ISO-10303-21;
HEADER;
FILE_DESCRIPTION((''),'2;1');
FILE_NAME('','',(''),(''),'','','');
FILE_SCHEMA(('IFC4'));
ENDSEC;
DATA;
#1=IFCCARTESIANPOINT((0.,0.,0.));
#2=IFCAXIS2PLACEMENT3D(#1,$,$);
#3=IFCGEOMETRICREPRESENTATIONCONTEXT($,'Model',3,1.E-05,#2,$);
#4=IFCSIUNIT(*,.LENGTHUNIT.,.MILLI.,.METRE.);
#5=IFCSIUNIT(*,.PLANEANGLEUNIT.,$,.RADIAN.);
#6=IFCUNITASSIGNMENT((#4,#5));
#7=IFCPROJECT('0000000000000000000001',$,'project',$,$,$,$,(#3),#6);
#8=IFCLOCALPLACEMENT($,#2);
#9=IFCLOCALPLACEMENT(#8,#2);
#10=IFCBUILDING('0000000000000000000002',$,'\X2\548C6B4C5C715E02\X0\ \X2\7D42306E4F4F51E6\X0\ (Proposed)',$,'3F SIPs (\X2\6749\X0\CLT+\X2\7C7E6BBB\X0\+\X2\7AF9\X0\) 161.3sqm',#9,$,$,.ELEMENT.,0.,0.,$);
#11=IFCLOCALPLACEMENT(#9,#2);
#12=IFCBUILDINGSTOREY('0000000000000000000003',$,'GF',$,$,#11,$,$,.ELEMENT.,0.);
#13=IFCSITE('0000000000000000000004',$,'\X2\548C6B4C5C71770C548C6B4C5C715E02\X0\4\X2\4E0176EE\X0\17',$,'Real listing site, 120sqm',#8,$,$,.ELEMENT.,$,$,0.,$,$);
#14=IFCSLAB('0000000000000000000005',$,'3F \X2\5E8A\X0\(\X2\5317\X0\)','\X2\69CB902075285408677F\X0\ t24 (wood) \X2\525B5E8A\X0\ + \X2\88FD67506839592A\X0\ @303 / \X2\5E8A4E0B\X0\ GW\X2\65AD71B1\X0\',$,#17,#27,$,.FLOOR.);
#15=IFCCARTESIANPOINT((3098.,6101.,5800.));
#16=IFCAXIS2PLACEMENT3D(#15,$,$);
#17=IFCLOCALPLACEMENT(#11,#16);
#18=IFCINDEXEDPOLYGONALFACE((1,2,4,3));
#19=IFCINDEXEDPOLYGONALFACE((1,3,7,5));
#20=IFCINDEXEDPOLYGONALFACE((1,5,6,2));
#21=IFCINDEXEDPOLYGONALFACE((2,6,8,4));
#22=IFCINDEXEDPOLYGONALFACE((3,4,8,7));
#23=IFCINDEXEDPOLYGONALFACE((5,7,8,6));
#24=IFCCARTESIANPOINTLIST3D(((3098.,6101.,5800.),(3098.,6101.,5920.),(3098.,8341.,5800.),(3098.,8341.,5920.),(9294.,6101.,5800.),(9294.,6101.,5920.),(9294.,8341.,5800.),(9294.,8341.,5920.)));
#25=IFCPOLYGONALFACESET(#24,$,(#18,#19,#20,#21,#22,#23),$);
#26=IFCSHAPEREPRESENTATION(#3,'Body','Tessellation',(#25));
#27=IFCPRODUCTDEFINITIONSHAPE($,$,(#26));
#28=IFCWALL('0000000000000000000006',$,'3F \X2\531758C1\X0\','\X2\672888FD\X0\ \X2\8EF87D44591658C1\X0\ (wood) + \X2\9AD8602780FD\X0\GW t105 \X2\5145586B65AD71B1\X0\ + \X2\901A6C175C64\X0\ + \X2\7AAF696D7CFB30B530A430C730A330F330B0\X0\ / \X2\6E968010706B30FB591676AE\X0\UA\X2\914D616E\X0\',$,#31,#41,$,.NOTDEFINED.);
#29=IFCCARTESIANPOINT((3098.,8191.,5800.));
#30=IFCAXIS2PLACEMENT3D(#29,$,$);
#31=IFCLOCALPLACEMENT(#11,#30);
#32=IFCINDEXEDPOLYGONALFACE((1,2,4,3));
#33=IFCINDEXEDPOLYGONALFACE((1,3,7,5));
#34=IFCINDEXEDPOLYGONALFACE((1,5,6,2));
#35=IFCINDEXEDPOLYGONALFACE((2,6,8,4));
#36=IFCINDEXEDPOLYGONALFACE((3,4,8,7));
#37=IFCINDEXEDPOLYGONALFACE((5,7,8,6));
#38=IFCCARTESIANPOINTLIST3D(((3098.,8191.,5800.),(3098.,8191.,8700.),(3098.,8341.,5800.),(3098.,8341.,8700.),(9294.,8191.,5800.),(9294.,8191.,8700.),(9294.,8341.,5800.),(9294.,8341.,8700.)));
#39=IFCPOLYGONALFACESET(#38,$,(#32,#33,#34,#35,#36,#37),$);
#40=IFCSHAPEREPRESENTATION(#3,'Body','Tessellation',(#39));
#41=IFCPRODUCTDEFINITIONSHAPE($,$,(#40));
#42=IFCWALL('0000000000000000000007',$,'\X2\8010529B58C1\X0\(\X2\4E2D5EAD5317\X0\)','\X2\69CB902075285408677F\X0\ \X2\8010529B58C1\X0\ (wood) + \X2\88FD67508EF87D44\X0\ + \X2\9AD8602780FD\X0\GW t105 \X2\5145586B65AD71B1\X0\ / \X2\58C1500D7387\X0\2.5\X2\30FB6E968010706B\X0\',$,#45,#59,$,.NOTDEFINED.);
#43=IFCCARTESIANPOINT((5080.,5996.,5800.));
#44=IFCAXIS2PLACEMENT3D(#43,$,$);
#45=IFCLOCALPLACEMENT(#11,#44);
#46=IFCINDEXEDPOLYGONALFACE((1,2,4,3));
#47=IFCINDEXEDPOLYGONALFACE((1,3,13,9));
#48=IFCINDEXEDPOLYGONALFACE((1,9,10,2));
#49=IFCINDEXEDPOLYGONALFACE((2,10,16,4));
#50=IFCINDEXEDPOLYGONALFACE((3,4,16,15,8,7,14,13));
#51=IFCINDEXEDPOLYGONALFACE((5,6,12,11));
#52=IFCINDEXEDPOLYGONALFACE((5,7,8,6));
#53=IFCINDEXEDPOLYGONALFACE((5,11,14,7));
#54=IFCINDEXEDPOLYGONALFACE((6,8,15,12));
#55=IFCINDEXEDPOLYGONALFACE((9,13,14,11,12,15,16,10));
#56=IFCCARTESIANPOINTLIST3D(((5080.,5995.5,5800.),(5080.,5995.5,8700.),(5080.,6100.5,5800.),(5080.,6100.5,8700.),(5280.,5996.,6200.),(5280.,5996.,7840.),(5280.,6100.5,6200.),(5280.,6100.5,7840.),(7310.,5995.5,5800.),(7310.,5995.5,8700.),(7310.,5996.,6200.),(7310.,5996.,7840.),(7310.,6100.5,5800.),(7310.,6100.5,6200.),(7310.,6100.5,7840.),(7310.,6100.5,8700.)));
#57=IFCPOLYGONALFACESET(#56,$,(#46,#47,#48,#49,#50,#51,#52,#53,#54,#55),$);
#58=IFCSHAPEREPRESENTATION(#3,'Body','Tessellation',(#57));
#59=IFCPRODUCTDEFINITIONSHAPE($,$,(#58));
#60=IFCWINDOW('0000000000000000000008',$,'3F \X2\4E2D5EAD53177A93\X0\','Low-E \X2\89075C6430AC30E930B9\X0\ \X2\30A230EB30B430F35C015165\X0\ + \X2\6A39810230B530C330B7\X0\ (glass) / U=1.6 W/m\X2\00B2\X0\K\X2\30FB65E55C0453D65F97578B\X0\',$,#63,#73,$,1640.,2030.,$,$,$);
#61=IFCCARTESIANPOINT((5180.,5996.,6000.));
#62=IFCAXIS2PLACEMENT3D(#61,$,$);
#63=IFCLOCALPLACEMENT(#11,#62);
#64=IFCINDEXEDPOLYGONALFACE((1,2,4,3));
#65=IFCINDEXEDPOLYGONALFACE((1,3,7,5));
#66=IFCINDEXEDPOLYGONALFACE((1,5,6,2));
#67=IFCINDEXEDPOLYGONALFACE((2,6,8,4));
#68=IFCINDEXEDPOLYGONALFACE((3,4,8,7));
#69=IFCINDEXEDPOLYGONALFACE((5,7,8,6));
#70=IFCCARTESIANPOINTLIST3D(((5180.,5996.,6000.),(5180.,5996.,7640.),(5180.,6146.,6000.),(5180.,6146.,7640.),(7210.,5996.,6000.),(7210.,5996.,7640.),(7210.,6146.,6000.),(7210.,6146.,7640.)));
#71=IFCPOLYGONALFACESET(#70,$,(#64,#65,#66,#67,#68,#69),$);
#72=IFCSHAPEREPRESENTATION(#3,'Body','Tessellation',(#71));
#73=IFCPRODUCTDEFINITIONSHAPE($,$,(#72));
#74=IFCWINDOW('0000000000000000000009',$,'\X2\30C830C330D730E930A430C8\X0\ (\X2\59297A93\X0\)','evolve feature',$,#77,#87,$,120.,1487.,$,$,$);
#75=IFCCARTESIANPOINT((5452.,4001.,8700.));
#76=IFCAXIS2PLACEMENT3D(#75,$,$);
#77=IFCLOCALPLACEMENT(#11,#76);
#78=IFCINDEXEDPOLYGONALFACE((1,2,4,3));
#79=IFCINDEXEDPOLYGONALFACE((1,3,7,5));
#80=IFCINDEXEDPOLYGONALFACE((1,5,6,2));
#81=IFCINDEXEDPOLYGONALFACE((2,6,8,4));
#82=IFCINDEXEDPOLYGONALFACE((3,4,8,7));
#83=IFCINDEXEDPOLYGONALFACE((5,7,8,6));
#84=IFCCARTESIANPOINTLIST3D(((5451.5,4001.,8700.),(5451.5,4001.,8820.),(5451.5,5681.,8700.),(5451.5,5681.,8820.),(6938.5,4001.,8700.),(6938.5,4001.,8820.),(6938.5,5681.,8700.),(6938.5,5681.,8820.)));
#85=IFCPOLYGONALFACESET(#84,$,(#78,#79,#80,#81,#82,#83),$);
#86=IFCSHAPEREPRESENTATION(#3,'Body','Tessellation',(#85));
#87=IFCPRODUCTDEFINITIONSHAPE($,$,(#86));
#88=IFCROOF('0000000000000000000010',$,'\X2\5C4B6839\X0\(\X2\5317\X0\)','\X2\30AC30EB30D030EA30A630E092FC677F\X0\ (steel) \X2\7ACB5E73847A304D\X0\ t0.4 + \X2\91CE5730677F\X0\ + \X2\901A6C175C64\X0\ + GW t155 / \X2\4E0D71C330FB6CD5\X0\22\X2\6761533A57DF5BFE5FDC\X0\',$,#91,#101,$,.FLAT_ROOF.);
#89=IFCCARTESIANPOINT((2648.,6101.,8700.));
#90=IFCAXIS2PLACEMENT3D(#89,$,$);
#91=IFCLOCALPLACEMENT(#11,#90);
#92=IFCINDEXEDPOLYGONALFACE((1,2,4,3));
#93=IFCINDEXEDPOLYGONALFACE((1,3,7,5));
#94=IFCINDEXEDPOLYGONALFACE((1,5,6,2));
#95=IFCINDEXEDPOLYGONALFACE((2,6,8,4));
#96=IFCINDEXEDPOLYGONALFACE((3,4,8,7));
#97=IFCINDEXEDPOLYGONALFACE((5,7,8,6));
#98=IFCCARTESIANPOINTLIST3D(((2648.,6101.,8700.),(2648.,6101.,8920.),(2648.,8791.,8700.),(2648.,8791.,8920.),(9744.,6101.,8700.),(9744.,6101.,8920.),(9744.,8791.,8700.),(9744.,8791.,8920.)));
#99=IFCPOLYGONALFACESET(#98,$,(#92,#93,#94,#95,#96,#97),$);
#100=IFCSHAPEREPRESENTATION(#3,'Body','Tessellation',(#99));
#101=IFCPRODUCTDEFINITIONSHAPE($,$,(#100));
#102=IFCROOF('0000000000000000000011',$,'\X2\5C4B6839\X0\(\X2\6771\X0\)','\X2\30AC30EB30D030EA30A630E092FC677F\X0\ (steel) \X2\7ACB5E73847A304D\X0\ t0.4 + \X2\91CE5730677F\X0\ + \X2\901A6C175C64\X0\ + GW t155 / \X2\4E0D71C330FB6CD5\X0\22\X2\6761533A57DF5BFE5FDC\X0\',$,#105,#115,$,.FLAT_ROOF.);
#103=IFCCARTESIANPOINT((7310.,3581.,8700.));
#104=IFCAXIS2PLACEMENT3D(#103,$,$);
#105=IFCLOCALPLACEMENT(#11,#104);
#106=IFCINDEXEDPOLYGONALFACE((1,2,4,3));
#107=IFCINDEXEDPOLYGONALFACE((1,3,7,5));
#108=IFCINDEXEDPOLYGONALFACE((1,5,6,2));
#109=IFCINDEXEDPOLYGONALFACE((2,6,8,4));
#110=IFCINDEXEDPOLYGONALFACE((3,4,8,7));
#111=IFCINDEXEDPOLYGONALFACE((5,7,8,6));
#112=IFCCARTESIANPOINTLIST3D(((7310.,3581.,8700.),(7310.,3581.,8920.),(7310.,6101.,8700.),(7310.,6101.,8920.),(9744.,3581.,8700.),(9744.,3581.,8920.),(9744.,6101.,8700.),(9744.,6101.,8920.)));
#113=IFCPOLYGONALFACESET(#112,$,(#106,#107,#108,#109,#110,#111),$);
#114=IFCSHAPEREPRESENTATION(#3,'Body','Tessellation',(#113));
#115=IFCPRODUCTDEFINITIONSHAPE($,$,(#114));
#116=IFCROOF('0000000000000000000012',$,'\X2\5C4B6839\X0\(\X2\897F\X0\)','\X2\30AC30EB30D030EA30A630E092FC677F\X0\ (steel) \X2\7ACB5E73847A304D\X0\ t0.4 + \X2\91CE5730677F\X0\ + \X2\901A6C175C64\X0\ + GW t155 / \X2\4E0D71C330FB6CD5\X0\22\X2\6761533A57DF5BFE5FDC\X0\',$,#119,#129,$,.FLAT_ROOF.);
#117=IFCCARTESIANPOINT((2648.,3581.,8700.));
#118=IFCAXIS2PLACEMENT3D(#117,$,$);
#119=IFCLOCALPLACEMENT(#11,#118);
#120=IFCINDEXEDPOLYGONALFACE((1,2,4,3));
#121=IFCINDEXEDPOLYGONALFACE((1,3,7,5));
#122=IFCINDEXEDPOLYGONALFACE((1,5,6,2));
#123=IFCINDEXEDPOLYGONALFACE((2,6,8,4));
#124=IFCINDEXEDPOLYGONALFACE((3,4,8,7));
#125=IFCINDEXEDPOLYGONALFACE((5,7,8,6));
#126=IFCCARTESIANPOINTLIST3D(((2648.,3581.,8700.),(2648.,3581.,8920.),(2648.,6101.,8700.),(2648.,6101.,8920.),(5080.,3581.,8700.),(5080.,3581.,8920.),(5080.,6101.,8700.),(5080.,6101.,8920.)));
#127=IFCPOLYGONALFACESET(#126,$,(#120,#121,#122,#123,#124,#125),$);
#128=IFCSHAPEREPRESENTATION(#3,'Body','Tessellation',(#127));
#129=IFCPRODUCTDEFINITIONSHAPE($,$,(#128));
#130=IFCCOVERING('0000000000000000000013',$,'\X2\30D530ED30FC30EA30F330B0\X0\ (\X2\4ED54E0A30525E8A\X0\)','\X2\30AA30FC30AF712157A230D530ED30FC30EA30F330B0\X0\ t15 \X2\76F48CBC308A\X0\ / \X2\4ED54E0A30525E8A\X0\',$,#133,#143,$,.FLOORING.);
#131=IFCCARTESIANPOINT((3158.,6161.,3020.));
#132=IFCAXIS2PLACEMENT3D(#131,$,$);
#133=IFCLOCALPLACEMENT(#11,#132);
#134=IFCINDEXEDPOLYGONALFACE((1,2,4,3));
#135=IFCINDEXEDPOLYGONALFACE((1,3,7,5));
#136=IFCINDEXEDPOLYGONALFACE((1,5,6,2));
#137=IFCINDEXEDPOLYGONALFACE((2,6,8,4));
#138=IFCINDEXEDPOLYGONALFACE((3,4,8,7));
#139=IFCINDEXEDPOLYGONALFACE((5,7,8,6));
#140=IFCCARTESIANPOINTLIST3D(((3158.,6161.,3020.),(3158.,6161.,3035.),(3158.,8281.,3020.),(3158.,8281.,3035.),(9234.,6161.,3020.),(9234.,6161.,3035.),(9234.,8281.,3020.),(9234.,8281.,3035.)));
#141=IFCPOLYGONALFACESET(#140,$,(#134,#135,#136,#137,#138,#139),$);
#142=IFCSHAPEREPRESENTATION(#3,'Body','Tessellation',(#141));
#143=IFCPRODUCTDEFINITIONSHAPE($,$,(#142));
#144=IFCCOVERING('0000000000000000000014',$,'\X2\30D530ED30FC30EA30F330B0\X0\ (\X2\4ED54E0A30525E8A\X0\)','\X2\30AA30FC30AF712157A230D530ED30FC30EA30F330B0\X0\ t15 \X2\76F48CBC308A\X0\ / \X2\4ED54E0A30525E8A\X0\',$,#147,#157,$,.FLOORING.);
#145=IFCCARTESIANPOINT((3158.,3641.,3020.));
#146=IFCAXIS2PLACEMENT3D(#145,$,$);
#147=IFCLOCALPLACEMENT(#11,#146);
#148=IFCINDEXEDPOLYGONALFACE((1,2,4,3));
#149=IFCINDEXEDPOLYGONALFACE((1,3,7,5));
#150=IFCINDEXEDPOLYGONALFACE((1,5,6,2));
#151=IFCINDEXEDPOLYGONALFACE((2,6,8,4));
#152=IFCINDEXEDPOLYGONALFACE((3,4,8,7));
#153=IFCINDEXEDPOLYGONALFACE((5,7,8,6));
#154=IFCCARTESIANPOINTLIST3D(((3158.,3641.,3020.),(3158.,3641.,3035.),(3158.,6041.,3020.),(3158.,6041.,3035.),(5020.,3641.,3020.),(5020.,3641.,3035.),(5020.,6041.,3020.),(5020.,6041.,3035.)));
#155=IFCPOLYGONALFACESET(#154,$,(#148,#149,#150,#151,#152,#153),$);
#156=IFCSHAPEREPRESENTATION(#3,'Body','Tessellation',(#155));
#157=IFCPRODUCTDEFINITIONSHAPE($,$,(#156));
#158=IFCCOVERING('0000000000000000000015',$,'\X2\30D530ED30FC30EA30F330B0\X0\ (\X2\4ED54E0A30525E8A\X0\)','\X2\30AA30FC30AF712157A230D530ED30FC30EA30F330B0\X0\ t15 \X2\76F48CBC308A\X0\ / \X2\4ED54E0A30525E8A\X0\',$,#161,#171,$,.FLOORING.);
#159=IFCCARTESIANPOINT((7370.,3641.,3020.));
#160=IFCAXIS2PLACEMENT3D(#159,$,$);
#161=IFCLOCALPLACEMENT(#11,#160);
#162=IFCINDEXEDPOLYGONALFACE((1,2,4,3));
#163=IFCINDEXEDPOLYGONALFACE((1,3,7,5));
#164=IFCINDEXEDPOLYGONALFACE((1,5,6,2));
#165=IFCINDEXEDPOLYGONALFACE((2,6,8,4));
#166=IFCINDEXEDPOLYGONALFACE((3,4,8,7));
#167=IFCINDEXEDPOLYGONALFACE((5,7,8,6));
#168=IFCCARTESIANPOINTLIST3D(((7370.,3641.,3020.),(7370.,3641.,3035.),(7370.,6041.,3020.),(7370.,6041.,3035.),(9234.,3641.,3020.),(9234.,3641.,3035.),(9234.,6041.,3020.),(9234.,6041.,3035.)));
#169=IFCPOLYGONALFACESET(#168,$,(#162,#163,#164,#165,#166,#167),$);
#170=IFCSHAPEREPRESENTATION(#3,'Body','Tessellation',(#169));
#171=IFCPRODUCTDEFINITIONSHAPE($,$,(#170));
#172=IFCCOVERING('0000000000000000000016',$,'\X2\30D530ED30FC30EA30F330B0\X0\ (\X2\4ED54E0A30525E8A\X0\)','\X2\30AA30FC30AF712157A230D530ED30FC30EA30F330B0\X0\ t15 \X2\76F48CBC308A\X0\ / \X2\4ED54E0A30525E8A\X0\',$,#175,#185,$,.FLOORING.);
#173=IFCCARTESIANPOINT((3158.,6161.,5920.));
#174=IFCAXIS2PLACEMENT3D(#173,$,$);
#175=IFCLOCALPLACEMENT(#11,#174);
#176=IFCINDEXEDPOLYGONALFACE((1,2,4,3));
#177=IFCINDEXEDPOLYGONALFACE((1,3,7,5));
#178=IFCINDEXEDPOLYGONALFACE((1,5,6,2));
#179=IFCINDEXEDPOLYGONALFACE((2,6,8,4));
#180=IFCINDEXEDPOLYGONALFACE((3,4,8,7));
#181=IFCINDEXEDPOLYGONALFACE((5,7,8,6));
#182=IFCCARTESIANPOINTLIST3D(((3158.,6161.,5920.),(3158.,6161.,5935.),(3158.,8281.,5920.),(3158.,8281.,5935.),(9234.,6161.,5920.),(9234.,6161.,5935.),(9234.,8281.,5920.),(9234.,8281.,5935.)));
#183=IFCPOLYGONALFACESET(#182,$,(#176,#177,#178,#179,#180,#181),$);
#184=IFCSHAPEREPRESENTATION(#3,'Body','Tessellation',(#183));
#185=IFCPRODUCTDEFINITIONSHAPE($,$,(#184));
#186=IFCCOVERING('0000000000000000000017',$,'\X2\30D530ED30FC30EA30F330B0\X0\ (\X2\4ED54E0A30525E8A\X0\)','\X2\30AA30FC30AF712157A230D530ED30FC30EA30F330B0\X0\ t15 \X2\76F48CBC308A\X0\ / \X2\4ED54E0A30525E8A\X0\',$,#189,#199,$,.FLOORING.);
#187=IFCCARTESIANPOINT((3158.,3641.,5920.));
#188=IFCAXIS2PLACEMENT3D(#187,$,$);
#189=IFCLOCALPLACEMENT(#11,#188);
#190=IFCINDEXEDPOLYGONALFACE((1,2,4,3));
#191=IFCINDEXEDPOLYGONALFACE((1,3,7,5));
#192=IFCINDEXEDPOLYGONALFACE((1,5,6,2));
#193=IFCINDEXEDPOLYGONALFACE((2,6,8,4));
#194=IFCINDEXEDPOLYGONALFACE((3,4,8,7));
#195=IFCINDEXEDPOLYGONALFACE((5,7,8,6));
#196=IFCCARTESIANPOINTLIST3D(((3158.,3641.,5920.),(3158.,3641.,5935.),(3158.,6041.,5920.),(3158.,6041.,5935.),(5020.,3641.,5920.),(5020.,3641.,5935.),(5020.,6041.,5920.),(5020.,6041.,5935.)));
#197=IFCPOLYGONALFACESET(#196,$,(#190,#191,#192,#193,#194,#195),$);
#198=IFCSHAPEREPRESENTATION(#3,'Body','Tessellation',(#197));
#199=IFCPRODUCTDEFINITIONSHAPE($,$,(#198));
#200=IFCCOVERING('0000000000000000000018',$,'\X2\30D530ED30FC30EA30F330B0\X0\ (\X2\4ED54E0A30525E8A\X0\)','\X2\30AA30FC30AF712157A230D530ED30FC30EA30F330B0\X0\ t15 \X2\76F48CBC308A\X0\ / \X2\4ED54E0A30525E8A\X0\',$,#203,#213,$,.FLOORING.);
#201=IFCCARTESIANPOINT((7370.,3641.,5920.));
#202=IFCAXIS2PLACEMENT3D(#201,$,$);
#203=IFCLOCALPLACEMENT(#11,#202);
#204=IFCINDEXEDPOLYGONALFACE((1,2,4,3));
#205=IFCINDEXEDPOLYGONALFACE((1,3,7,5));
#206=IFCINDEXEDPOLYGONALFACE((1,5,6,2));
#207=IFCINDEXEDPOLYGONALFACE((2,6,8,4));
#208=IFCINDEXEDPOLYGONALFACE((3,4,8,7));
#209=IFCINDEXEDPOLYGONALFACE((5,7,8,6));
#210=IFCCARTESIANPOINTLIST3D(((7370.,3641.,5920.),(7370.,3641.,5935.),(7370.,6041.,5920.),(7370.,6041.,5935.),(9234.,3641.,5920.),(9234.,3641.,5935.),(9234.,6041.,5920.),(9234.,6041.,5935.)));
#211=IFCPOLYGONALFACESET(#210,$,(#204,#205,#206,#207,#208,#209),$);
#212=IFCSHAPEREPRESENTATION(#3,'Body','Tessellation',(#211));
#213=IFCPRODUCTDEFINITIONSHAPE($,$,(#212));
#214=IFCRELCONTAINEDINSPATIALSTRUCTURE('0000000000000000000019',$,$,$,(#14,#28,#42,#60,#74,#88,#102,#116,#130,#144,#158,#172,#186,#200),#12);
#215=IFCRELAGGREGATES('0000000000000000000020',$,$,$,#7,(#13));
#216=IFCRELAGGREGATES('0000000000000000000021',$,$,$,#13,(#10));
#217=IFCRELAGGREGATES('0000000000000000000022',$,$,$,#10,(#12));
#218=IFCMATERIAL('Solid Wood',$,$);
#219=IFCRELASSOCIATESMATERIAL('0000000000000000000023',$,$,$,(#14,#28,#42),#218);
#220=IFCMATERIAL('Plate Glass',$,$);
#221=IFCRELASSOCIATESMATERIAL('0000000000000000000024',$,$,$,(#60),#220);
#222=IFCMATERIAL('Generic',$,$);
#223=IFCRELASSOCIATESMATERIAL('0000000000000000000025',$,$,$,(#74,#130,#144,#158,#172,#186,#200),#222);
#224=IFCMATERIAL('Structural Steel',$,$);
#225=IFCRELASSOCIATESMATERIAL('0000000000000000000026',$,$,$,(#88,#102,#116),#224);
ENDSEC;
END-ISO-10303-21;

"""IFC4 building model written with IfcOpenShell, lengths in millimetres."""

from ifc_helpers import new_model, si_unit, frame, frame_2d, origin, place, context, project, spatial, rectangle, extrude, material, element, fill, save


model = new_model("IFC4")

# Units and contexts
model_context = context("Model", 3, precision=1e-05, world=origin())
ifc_project = project(units=[si_unit("LENGTHUNIT", "METRE", prefix="MILLI"), si_unit("PLANEANGLEUNIT", "RADIAN")], contexts=[model_context])

# Site, building, storey
site_placement = place(None, origin())
site = spatial("IfcSite", under=ifc_project, at=site_placement, Name="和歌山県和歌山市4丁目17", ObjectType="Real listing site, 120sqm", CompositionType="ELEMENT", RefElevation=0.0)
building_placement = place(site_placement, origin())
building = spatial("IfcBuilding", under=site, at=building_placement, Name="和歌山市 終の住処 (Proposed)", ObjectType="3F SIPs (杉CLT+籾殻+竹) 161.3sqm", CompositionType="ELEMENT", ElevationOfRefHeight=0.0, ElevationOfTerrain=0.0)
storey_placement = place(building_placement, origin())
storey = spatial("IfcBuildingStorey", under=building, at=storey_placement, Name="GF", CompositionType="ELEMENT", Elevation=0.0)

# Slab
ifc_material_1 = material(Name="Solid Wood")
slab_placement = place(storey_placement, frame((3098.0, 6101.0, 5800.0)))
element("IfcSlab", 1, at=slab_placement, inside=storey, material=ifc_material_1, Name="3F 床(北)", Description="構造用合板 t24 (wood) 剛床 + 製材根太 @303 / 床下 GW断熱", PredefinedType="FLOOR", context=model_context, shape_type="SweptSolid", body=[
    extrude(rectangle(XDim=6196.0, YDim=2240.0, at=frame_2d((3098.0, 1120.0))), frame((3098.0, 6101.0, 5800.0)), (0.0, 0.0, 1.0), 120.0),
])

# Wall
wall_1_placement = place(storey_placement, frame((3098.0, 8191.0, 5800.0)))
element("IfcWall", 2, at=wall_1_placement, inside=storey, material=ifc_material_1, Name="3F 北壁", Description="木製 軸組外壁 (wood) + 高性能GW t105 充填断熱 + 通気層 + 窯業系サイディング / 準耐火・外皮UA配慮", PredefinedType="NOTDEFINED", context=model_context, shape_type="SweptSolid", body=[
    extrude(rectangle(XDim=6196.0, YDim=150.0, at=frame_2d((3098.0, 75.0))), frame((3098.0, 8191.0, 5800.0)), (0.0, 0.0, 1.0), 2900.0),
])

# Wall, opening, window
wall_2_placement = place(storey_placement, frame((5080.0, 5996.0, 5800.0)))
wall_2 = element("IfcWall", 3, at=wall_2_placement, inside=storey, material=ifc_material_1, Name="耐力壁(中庭北)", Description="構造用合板 耐力壁 (wood) + 製材軸組 + 高性能GW t105 充填断熱 / 壁倍率2.5・準耐火", PredefinedType="NOTDEFINED", context=model_context, shape_type="SweptSolid", body=[
    extrude(rectangle(XDim=2230.0, YDim=105.0, at=frame_2d((1115.0, 52.0))), frame((5080.0, 5996.0, 5800.0)), (0.0, 0.0, 1.0), 2900.0),
])
opening_placement = place(storey_placement, frame((5180.0, 5996.0, 6000.0)))
opening = element("IfcOpeningElement", 4, at=opening_placement, cuts=wall_2, PredefinedType="NOTDEFINED", context=model_context, shape_type="SweptSolid", body=[
    extrude(rectangle(XDim=2030.0, YDim=150.0, at=frame_2d((1015.0, 75.0))), frame((5180.0, 5996.0, 6000.0)), (0.0, 0.0, 1.0), 1640.0),
])
ifc_material_2 = material(Name="Plate Glass")
window_1_placement = place(storey_placement, frame((5180.0, 5996.0, 6000.0)))
window_1 = element("IfcWindow", 5, at=window_1_placement, inside=storey, material=ifc_material_2, Name="3F 中庭北窓", Description="Low-E 複層ガラス アルゴン封入 + 樹脂サッシ (glass) / U=1.6 W/m²K・日射取得型", OverallHeight=1640.0, OverallWidth=2030.0, context=model_context, shape_type="SweptSolid", body=[
    extrude(rectangle(XDim=2030.0, YDim=150.0, at=frame_2d((1015.0, 75.0))), frame((5180.0, 5996.0, 6000.0)), (0.0, 0.0, 1.0), 1640.0),
])
fill(opening, window_1)

# Window
ifc_material_3 = material(Name="Generic")
window_2_placement = place(storey_placement, frame((5452.0, 4001.0, 8700.0)))
element("IfcWindow", 6, at=window_2_placement, inside=storey, material=ifc_material_3, Name="トップライト (天窓)", Description="evolve feature", OverallHeight=120.0, OverallWidth=1487.0, context=model_context, shape_type="SweptSolid", body=[
    extrude(rectangle(XDim=1487.0, YDim=1680.0, at=frame_2d((743.0, 840.0))), frame((5452.0, 4001.0, 8700.0)), (0.0, 0.0, 1.0), 120.0),
])

# Roofs
ifc_material_4 = material(Name="Structural Steel")
roof_1_placement = place(storey_placement, frame((2648.0, 6101.0, 8700.0)))
element("IfcRoof", 7, at=roof_1_placement, inside=storey, material=ifc_material_4, Name="屋根(北)", Description="ガルバリウム鋼板 (steel) 立平葺き t0.4 + 野地板 + 通気層 + GW t155 / 不燃・法22条区域対応", PredefinedType="FLAT_ROOF", context=model_context, shape_type="SweptSolid", body=[
    extrude(rectangle(XDim=7096.0, YDim=2690.0, at=frame_2d((3548.0, 1345.0))), frame((2648.0, 6101.0, 8700.0)), (0.0, 0.0, 1.0), 220.0),
])
roof_2_placement = place(storey_placement, frame((7310.0, 3581.0, 8700.0)))
element("IfcRoof", 8, at=roof_2_placement, inside=storey, material=ifc_material_4, Name="屋根(東)", Description="ガルバリウム鋼板 (steel) 立平葺き t0.4 + 野地板 + 通気層 + GW t155 / 不燃・法22条区域対応", PredefinedType="FLAT_ROOF", context=model_context, shape_type="SweptSolid", body=[
    extrude(rectangle(XDim=2434.0, YDim=2520.0, at=frame_2d((1217.0, 1260.0))), frame((7310.0, 3581.0, 8700.0)), (0.0, 0.0, 1.0), 220.0),
])
roof_3_placement = place(storey_placement, frame((2648.0, 3581.0, 8700.0)))
element("IfcRoof", 9, at=roof_3_placement, inside=storey, material=ifc_material_4, Name="屋根(西)", Description="ガルバリウム鋼板 (steel) 立平葺き t0.4 + 野地板 + 通気層 + GW t155 / 不燃・法22条区域対応", PredefinedType="FLAT_ROOF", context=model_context, shape_type="SweptSolid", body=[
    extrude(rectangle(XDim=2432.0, YDim=2520.0, at=frame_2d((1216.0, 1260.0))), frame((2648.0, 3581.0, 8700.0)), (0.0, 0.0, 1.0), 220.0),
])

# Coverings
covering_1_placement = place(storey_placement, frame((3158.0, 6161.0, 3020.0)))
element("IfcCovering", 10, at=covering_1_placement, inside=storey, material=ifc_material_3, Name="フローリング (仕上げ床)", Description="オーク無垢フローリング t15 直貼り / 仕上げ床", PredefinedType="FLOORING", context=model_context, shape_type="SweptSolid", body=[
    extrude(rectangle(XDim=6076.0, YDim=2120.0, at=frame_2d((3038.0, 1060.0))), frame((3158.0, 6161.0, 3020.0)), (0.0, 0.0, 1.0), 15.0),
])
covering_2_placement = place(storey_placement, frame((3158.0, 3641.0, 3020.0)))
element("IfcCovering", 11, at=covering_2_placement, inside=storey, material=ifc_material_3, Name="フローリング (仕上げ床)", Description="オーク無垢フローリング t15 直貼り / 仕上げ床", PredefinedType="FLOORING", context=model_context, shape_type="SweptSolid", body=[
    extrude(rectangle(XDim=1862.0, YDim=2400.0, at=frame_2d((931.0, 1200.0))), frame((3158.0, 3641.0, 3020.0)), (0.0, 0.0, 1.0), 15.0),
])
covering_3_placement = place(storey_placement, frame((7370.0, 3641.0, 3020.0)))
element("IfcCovering", 12, at=covering_3_placement, inside=storey, material=ifc_material_3, Name="フローリング (仕上げ床)", Description="オーク無垢フローリング t15 直貼り / 仕上げ床", PredefinedType="FLOORING", context=model_context, shape_type="SweptSolid", body=[
    extrude(rectangle(XDim=1864.0, YDim=2400.0, at=frame_2d((932.0, 1200.0))), frame((7370.0, 3641.0, 3020.0)), (0.0, 0.0, 1.0), 15.0),
])
covering_4_placement = place(storey_placement, frame((3158.0, 6161.0, 5920.0)))
element("IfcCovering", 13, at=covering_4_placement, inside=storey, material=ifc_material_3, Name="フローリング (仕上げ床)", Description="オーク無垢フローリング t15 直貼り / 仕上げ床", PredefinedType="FLOORING", context=model_context, shape_type="SweptSolid", body=[
    extrude(rectangle(XDim=6076.0, YDim=2120.0, at=frame_2d((3038.0, 1060.0))), frame((3158.0, 6161.0, 5920.0)), (0.0, 0.0, 1.0), 15.0),
])
covering_5_placement = place(storey_placement, frame((3158.0, 3641.0, 5920.0)))
element("IfcCovering", 14, at=covering_5_placement, inside=storey, material=ifc_material_3, Name="フローリング (仕上げ床)", Description="オーク無垢フローリング t15 直貼り / 仕上げ床", PredefinedType="FLOORING", context=model_context, shape_type="SweptSolid", body=[
    extrude(rectangle(XDim=1862.0, YDim=2400.0, at=frame_2d((931.0, 1200.0))), frame((3158.0, 3641.0, 5920.0)), (0.0, 0.0, 1.0), 15.0),
])
covering_6_placement = place(storey_placement, frame((7370.0, 3641.0, 5920.0)))
element("IfcCovering", 15, at=covering_6_placement, inside=storey, material=ifc_material_3, Name="フローリング (仕上げ床)", Description="オーク無垢フローリング t15 直貼り / 仕上げ床", PredefinedType="FLOORING", context=model_context, shape_type="SweptSolid", body=[
    extrude(rectangle(XDim=1864.0, YDim=2400.0, at=frame_2d((932.0, 1200.0))), frame((7370.0, 3641.0, 5920.0)), (0.0, 0.0, 1.0), 15.0),
])

save(model, "model.ifc")
